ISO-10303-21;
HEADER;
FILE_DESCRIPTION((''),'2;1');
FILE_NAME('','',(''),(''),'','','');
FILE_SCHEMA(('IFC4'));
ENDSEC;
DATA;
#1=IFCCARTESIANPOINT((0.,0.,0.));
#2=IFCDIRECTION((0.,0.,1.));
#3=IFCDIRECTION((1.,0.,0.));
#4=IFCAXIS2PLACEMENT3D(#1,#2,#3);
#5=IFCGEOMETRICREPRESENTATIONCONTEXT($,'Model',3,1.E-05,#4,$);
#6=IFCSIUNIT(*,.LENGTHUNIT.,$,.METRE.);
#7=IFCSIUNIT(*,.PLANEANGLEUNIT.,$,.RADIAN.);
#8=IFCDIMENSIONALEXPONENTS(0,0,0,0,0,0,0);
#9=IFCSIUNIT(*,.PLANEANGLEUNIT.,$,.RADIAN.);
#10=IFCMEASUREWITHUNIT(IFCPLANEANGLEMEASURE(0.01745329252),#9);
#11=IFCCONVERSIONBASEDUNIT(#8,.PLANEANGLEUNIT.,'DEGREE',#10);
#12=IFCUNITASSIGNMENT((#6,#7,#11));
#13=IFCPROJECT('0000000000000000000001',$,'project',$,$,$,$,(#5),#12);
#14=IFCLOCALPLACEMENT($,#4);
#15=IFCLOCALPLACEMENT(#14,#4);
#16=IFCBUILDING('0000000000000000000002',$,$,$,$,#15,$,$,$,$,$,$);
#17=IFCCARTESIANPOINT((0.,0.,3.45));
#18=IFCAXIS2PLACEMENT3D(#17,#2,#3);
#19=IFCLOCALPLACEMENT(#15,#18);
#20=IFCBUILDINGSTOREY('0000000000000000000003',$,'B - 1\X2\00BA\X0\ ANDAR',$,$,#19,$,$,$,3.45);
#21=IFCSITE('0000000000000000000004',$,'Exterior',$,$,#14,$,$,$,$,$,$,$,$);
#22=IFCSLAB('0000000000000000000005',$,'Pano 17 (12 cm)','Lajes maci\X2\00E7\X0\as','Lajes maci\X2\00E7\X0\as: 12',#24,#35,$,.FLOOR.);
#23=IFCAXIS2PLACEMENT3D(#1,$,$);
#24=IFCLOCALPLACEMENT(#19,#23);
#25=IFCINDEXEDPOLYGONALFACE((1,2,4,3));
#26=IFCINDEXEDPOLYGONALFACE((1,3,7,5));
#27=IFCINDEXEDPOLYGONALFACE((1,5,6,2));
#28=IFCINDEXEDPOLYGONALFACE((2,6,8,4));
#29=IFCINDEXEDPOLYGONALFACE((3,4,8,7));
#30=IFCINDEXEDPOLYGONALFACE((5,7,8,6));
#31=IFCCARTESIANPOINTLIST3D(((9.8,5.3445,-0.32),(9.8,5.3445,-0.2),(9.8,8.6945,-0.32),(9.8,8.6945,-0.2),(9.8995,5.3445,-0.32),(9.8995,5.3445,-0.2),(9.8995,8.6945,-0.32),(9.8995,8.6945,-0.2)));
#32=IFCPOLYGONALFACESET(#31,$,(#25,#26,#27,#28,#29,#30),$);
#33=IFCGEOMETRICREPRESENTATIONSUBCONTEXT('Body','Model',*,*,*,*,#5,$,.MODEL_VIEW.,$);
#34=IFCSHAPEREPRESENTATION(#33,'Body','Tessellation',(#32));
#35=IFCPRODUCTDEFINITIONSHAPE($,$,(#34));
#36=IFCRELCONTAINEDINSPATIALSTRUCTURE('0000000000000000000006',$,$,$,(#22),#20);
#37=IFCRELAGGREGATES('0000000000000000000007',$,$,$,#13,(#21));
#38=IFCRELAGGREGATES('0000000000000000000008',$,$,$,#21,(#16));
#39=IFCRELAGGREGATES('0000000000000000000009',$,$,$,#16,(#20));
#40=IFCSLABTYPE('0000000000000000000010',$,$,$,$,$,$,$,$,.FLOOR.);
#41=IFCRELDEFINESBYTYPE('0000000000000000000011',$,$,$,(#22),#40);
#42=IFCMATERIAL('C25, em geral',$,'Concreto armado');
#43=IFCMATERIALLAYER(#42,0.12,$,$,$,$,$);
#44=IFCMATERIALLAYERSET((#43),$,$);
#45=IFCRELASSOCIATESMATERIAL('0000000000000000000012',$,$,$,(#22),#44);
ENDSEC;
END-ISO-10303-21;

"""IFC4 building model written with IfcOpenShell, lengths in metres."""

from ifc_helpers import new_model, entity, si_unit, converted_unit, frame, origin_with_axes, place, context, subcontext, project, spatial, polyline, outline, extrude, material, layer, layer_set, layer_usage, type_object, element, save


model = new_model("IFC4")

# Units and contexts
model_context = context("Model", 3, precision=1e-05, world=origin_with_axes())
body_context = subcontext(model_context, "Body", "Model", "MODEL_VIEW")
ifc_project = project(units=[si_unit("LENGTHUNIT", "METRE"), si_unit("PLANEANGLEUNIT", "RADIAN"), converted_unit("PLANEANGLEUNIT", "DEGREE", entity("IfcPlaneAngleMeasure", 0.01745329252), si_unit("PLANEANGLEUNIT", "RADIAN"), dimensions=[0, 0, 0, 0, 0, 0, 0])], contexts=[model_context])

# Site, building, storey
site_placement = place(None, origin_with_axes())
site = spatial("IfcSite", under=ifc_project, at=site_placement, Name="Exterior")
building_placement = place(site_placement, origin_with_axes())
building = spatial("IfcBuilding", under=site, at=building_placement)
storey_placement = place(building_placement, frame((0.0, 0.0, 3.45), z_axis=(0.0, 0.0, 1.0), x_axis=(1.0, 0.0, 0.0)))
storey = spatial("IfcBuildingStorey", under=building, at=storey_placement, Name="B - 1º ANDAR", Elevation=3.45)

# Slab
ifc_material = material(Name="C25, em geral", Category="Concreto armado")
ifc_layer = layer(ifc_material, 0.12)
ifc_layer_set = layer_set([ifc_layer])
ifc_layer_usage = layer_usage(ifc_layer_set, "AXIS3", "POSITIVE", 0.0)
slab_type = type_object("IfcSlabType", PredefinedType="FLOOR")
slab_placement = place(storey_placement, frame((0.0, 0.0, -0.32), z_axis=(0.0, 0.0, 1.0), x_axis=(1.0, 0.0, 0.0)))
element("IfcSlab", 1, at=slab_placement, inside=storey, type_object=slab_type, material=ifc_layer_usage, Name="Pano 17 (12 cm)", Description="Lajes maciças", ObjectType="Lajes maciças: 12", PredefinedType="FLOOR", context=body_context, shape_type="SweptSolid", body=[
    extrude(outline(polyline([(9.8, 8.6945), (9.8, 5.3445), (9.8995, 5.3445), (9.8995, 8.6945), (9.8, 8.6945)])), origin_with_axes(), (0.0, 0.0, 1.0), 0.12),
])

save(model, "model.ifc")
